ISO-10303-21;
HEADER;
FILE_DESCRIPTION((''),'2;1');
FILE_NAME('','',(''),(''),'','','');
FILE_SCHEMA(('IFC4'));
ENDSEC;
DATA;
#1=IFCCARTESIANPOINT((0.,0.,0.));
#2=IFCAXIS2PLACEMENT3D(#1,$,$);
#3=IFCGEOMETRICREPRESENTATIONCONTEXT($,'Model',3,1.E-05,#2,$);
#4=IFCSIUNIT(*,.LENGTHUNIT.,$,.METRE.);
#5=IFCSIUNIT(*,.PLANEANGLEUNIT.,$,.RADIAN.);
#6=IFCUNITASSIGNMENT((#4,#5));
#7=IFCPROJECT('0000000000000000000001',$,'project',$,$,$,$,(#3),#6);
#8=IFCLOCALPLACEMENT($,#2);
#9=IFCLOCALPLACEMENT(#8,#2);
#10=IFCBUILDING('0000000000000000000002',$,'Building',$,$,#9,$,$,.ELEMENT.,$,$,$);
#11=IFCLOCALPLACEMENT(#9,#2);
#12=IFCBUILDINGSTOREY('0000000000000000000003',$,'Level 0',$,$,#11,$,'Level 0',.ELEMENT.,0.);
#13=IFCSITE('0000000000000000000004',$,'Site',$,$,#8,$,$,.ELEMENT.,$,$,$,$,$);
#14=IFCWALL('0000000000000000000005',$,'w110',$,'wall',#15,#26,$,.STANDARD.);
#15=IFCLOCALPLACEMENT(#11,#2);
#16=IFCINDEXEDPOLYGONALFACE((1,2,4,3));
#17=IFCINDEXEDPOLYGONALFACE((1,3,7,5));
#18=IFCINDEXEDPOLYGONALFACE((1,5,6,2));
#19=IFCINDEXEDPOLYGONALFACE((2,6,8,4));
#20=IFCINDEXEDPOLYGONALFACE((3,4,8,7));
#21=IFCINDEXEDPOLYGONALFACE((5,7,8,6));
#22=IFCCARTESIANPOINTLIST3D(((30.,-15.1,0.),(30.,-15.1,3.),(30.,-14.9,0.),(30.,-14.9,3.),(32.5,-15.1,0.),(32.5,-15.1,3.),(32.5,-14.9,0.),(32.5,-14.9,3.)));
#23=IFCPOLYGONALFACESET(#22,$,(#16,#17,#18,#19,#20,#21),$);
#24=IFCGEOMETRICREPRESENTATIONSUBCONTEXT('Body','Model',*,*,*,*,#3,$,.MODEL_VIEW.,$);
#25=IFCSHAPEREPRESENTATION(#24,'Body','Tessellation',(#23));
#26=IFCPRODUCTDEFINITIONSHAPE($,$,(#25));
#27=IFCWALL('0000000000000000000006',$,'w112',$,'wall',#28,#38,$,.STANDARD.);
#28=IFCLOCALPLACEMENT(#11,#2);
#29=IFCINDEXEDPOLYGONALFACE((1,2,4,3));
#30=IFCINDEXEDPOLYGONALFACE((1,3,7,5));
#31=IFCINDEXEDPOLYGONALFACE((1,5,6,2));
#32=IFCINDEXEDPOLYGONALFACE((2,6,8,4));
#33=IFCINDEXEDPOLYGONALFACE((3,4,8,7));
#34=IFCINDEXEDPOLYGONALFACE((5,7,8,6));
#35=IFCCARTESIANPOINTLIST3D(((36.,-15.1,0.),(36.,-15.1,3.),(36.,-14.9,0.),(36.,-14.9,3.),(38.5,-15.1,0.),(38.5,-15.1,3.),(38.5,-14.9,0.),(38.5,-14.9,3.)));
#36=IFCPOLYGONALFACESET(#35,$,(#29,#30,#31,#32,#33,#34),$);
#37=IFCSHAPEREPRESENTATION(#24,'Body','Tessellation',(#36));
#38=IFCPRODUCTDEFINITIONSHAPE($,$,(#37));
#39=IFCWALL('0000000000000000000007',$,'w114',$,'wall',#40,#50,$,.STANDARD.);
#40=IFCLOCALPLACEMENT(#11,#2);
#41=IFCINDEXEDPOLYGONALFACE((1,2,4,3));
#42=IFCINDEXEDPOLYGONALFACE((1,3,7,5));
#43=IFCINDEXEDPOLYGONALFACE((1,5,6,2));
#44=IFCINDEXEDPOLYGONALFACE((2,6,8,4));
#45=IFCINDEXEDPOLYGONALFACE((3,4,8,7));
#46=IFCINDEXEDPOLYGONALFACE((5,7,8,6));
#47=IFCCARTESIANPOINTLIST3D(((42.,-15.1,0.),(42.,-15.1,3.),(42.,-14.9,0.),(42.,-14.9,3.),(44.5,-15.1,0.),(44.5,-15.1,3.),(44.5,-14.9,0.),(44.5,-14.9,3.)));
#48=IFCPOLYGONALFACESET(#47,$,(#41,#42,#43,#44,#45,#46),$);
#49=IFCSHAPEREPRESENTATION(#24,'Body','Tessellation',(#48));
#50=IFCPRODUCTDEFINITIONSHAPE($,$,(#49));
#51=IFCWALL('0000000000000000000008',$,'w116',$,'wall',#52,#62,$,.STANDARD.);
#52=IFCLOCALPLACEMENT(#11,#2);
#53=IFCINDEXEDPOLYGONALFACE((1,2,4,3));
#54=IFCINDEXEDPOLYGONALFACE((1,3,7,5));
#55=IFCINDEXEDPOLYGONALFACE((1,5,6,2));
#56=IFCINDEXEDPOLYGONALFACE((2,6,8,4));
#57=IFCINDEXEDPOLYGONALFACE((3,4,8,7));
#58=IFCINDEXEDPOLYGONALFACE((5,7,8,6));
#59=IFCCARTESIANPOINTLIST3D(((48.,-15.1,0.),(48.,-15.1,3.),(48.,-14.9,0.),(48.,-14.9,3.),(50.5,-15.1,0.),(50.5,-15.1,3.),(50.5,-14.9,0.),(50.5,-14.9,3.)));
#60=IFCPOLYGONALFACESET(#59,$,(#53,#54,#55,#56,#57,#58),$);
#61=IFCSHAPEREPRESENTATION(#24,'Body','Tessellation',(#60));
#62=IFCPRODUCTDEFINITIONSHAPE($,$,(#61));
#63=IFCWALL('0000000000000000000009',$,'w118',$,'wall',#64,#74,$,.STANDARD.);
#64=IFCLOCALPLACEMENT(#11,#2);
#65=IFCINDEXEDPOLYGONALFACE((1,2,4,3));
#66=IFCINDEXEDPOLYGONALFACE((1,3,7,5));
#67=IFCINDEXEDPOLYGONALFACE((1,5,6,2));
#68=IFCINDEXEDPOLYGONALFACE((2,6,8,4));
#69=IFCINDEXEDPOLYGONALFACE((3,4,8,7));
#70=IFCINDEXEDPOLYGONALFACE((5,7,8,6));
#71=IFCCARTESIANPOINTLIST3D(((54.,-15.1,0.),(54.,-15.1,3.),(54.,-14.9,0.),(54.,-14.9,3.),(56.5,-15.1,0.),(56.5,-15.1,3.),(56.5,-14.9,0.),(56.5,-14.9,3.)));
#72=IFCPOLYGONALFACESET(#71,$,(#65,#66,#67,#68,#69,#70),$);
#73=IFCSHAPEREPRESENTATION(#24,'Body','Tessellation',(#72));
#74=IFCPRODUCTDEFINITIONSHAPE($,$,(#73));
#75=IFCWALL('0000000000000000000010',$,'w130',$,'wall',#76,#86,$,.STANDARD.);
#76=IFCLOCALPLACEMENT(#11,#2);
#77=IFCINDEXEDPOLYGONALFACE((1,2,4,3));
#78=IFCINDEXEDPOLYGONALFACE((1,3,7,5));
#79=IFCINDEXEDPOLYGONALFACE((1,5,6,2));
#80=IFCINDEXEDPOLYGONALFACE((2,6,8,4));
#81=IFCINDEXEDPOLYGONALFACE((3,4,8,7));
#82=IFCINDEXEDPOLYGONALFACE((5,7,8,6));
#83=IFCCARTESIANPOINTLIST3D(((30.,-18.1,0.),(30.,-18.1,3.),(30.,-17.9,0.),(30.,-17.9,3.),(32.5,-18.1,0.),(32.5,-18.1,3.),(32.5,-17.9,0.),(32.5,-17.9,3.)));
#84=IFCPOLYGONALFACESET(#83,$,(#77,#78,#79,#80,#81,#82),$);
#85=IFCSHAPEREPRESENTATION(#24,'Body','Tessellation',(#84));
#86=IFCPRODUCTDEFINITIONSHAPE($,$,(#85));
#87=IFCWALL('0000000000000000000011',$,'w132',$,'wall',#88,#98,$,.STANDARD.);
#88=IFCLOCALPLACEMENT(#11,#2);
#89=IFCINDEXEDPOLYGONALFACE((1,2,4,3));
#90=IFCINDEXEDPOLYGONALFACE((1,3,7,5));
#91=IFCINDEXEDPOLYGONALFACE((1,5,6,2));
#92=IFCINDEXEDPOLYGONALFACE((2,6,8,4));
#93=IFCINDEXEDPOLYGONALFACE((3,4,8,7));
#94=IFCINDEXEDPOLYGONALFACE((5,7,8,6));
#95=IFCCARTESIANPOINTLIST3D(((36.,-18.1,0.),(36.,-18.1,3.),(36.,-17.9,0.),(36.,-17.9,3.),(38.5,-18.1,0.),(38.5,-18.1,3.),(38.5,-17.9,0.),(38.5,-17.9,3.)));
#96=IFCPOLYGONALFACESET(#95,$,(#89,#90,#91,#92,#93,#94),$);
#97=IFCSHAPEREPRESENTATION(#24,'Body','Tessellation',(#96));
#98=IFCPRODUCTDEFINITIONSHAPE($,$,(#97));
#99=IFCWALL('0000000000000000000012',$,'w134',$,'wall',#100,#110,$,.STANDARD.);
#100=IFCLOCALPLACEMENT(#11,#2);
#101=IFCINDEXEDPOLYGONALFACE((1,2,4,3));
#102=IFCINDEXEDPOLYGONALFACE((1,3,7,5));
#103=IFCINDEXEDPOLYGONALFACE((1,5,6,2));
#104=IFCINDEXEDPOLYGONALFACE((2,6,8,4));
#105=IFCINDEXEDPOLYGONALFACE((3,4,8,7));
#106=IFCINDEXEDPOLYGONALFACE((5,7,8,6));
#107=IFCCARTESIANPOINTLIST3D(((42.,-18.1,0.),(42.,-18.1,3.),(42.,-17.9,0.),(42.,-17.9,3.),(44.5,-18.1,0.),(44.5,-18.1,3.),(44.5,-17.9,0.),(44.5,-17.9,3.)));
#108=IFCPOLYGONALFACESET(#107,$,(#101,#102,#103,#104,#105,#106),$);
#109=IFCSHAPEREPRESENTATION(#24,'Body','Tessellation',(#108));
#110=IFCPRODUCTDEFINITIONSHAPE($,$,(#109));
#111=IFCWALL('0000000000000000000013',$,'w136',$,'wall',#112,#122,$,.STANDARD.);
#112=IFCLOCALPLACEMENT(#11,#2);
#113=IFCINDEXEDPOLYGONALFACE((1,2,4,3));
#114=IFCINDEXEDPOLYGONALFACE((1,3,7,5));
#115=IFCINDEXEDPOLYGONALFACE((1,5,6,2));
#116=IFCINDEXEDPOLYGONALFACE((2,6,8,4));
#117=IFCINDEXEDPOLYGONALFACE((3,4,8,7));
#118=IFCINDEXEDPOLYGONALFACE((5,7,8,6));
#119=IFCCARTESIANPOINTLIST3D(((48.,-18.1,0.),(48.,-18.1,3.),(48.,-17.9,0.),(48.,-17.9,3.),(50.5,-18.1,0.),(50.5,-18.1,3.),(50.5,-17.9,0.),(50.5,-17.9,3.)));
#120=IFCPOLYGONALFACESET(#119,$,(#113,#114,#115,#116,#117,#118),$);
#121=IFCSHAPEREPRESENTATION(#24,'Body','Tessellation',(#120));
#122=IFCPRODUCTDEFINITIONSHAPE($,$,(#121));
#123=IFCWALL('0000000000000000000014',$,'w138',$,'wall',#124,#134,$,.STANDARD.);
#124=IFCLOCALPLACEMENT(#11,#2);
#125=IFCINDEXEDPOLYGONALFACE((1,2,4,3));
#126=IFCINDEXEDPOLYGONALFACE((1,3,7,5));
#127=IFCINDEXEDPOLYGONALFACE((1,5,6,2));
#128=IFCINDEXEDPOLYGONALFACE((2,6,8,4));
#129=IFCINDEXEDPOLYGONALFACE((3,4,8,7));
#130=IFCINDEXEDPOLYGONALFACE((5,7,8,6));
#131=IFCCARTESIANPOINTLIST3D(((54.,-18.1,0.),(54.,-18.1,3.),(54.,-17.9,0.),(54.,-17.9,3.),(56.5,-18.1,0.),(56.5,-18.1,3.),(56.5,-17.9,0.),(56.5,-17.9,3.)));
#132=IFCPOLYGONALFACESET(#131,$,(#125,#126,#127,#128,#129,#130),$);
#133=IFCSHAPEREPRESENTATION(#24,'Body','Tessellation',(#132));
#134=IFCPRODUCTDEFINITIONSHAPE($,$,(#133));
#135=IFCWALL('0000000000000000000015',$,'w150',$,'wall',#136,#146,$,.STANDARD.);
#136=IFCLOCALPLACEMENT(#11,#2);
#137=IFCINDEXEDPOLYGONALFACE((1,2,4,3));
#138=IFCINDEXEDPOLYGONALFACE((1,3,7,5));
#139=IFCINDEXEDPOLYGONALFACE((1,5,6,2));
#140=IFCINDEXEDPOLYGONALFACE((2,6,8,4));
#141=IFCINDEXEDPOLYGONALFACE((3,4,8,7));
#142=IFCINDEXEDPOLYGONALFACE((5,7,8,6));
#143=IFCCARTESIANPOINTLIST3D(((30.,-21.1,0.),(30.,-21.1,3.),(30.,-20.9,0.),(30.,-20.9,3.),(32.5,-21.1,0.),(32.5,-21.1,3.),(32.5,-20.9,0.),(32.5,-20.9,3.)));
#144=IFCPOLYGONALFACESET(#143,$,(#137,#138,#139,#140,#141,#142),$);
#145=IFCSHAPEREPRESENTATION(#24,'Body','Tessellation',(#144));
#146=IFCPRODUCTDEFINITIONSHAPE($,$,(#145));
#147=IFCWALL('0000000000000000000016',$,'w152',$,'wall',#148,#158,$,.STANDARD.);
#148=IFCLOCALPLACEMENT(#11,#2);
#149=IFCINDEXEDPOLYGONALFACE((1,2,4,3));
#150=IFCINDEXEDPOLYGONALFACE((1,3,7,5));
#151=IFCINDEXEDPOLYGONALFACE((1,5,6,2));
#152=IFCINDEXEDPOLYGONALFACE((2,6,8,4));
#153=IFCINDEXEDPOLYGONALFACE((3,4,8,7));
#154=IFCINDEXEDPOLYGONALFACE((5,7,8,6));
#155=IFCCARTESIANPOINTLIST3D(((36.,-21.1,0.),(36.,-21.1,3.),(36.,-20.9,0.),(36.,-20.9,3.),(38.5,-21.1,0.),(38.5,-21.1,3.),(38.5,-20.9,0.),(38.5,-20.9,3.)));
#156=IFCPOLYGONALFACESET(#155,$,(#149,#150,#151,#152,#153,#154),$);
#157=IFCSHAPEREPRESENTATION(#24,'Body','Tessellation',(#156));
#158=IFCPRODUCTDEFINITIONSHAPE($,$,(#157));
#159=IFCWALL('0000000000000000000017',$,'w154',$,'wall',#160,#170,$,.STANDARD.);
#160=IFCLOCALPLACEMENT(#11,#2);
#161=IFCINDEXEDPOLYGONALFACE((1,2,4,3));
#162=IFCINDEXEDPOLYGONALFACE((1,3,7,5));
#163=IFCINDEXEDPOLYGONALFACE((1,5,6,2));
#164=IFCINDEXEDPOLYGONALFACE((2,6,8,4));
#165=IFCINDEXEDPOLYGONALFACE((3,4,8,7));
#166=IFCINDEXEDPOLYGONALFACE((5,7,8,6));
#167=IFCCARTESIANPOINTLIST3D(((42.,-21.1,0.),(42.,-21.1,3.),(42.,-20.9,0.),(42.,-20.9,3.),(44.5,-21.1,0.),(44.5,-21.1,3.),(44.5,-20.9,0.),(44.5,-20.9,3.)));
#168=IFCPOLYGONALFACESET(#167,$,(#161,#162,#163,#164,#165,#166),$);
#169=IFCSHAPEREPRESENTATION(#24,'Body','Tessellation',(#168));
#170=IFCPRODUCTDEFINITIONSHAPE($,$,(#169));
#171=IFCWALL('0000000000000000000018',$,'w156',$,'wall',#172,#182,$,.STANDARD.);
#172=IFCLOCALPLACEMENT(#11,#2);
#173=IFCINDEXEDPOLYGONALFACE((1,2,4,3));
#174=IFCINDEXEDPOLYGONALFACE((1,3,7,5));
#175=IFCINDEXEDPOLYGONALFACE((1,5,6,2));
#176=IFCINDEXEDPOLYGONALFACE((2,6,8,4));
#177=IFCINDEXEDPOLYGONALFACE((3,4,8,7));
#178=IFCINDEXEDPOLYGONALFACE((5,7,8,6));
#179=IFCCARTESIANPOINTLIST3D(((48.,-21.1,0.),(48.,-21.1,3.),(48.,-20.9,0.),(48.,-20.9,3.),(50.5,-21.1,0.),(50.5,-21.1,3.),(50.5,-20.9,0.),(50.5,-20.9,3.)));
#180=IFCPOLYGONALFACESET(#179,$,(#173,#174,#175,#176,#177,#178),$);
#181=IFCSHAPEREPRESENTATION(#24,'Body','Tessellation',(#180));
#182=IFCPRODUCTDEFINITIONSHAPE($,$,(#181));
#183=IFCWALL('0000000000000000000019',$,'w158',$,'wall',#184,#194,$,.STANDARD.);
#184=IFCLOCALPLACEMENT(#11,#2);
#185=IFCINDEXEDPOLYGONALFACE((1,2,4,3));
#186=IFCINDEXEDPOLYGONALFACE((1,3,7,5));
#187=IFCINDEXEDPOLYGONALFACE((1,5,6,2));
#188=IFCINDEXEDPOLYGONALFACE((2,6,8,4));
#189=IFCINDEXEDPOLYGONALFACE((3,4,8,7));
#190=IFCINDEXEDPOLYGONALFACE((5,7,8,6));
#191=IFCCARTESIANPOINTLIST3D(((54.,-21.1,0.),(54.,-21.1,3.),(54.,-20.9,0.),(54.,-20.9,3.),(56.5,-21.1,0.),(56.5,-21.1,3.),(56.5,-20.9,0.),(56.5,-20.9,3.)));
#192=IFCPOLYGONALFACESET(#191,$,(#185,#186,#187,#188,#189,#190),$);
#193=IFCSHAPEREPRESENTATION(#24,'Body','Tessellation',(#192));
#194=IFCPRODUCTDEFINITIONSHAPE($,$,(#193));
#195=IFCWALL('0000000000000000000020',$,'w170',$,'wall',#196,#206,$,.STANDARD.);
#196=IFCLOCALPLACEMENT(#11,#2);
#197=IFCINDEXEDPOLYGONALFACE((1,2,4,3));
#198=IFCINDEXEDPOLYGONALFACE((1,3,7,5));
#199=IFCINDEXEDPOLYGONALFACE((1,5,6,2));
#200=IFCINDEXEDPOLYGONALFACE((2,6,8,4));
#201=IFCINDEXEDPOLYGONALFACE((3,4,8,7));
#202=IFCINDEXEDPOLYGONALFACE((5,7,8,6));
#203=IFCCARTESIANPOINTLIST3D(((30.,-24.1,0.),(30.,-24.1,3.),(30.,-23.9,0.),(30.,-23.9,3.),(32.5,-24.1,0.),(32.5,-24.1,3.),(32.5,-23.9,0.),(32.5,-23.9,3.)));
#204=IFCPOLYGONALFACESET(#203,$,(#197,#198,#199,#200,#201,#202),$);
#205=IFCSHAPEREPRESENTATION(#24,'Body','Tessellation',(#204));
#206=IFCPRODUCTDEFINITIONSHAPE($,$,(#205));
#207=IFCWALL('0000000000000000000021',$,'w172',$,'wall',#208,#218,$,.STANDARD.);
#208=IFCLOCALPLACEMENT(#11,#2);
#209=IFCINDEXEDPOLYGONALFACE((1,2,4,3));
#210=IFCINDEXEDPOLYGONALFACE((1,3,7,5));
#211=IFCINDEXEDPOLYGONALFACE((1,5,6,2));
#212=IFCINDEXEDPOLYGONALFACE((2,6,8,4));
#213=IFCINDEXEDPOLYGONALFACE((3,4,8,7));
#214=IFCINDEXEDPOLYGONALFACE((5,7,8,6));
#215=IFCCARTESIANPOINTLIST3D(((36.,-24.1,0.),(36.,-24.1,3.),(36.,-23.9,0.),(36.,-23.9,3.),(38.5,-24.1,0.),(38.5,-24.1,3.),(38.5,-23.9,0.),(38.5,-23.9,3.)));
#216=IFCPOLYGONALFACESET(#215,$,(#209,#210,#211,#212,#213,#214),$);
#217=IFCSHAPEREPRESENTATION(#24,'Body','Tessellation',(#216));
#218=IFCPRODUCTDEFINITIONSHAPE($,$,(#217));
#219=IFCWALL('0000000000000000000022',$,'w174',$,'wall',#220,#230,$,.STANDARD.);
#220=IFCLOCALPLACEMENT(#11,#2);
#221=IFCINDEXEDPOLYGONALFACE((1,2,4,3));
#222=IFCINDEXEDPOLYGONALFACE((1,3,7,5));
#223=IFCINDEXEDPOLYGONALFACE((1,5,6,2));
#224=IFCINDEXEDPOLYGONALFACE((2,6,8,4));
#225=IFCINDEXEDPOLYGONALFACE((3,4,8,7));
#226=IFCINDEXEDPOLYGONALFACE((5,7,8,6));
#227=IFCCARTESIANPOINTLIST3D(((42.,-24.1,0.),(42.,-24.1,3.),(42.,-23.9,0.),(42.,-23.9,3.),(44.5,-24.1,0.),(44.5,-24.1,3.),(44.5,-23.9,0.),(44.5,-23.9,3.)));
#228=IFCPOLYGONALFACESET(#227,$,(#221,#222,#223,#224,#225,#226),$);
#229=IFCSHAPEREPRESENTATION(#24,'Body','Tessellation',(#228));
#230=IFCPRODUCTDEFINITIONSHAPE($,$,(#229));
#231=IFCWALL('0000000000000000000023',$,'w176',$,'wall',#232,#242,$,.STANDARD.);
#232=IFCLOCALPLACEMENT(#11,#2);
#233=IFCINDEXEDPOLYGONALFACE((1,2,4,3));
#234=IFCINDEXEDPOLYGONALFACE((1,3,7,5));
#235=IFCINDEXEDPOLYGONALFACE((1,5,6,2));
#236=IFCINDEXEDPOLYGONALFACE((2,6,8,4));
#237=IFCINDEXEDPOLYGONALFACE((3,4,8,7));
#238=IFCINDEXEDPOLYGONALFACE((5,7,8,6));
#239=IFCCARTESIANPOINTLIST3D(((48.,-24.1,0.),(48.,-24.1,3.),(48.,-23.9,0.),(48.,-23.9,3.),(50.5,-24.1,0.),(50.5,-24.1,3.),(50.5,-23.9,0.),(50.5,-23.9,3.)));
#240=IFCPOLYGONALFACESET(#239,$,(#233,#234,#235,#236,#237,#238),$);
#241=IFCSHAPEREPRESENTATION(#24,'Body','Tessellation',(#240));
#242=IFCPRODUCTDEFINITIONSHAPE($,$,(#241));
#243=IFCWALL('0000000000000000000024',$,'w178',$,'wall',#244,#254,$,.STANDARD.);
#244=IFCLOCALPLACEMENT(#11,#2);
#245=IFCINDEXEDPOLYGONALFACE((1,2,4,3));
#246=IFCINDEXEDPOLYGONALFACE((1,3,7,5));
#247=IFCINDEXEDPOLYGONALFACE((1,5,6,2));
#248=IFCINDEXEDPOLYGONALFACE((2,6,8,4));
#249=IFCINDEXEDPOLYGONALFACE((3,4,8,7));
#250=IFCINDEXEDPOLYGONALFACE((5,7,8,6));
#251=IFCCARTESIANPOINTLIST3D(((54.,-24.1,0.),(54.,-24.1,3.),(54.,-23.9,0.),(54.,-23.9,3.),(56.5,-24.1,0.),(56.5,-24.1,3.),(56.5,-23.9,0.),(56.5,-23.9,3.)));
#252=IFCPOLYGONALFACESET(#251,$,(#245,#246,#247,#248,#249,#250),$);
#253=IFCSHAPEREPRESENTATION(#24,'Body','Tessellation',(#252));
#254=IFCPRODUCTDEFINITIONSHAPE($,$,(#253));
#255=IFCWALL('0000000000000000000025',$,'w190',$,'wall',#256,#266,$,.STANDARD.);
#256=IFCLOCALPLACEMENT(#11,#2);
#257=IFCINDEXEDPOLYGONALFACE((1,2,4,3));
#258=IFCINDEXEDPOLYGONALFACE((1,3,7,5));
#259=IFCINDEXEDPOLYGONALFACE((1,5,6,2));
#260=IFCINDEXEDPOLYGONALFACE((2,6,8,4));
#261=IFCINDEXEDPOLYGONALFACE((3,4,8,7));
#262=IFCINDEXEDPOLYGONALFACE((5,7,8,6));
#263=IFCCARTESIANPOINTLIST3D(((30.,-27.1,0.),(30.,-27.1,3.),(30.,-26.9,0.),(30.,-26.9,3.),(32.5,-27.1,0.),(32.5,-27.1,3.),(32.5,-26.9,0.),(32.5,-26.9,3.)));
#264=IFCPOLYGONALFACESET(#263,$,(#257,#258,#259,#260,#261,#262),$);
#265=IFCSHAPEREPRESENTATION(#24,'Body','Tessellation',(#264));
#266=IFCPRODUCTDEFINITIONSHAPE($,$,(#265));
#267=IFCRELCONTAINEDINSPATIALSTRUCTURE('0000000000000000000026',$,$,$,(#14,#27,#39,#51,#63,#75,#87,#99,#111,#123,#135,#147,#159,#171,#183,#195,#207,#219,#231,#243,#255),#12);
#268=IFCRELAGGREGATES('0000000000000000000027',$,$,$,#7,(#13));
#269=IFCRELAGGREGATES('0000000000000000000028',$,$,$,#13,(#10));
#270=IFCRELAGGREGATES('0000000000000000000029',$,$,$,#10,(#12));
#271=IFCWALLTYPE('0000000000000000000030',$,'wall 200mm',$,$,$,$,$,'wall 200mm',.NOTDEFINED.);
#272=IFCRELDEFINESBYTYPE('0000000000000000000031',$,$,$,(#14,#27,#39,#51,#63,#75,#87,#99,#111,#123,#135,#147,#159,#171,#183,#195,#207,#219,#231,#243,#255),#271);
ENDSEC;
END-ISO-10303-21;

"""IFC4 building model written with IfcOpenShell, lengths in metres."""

from ifc_helpers import new_model, si_unit, frame, frame_2d, origin, place, context, subcontext, project, spatial, rectangle, extrude, type_object, element, save


model = new_model("IFC4")

# Units and contexts
model_context = context("Model", 3, precision=1e-05, world=origin())
body_context = subcontext(model_context, "Body", "Model", "MODEL_VIEW")
ifc_project = project(units=[si_unit("LENGTHUNIT", "METRE"), si_unit("PLANEANGLEUNIT", "RADIAN")], contexts=[model_context])

# Site, building, storey
site_placement = place(None, origin())
site = spatial("IfcSite", under=ifc_project, at=site_placement, Name="Site", CompositionType="ELEMENT")
building_placement = place(site_placement, origin())
building = spatial("IfcBuilding", under=site, at=building_placement, Name="Building", CompositionType="ELEMENT")
storey_placement = place(building_placement, origin())
storey = spatial("IfcBuildingStorey", under=building, at=storey_placement, Name="Level 0", LongName="Level 0", CompositionType="ELEMENT", Elevation=0.0)

# Walls
wall_type = type_object("IfcWallType", Name="wall 200mm", ElementType="wall 200mm", PredefinedType="NOTDEFINED")
for number, where, z_axis, x_axis, name in (
    (1, (30.0, -15.0, 0.0), (0.0, 0.0, 1.0), (1.0, 0.0, 0.0), "w110"),
    (2, (36.0, -15.0, 0.0), (0.0, 0.0, 1.0), (1.0, 0.0, 0.0), "w112"),
    (3, (42.0, -15.0, 0.0), (0.0, 0.0, 1.0), (1.0, 0.0, 0.0), "w114"),
    (4, (48.0, -15.0, 0.0), (0.0, 0.0, 1.0), (1.0, 0.0, 0.0), "w116"),
    (5, (54.0, -15.0, 0.0), (0.0, 0.0, 1.0), (1.0, 0.0, 0.0), "w118"),
    (6, (30.0, -18.0, 0.0), (0.0, 0.0, 1.0), (1.0, 0.0, 0.0), "w130"),
    (7, (36.0, -18.0, 0.0), (0.0, 0.0, 1.0), (1.0, 0.0, 0.0), "w132"),
    (8, (42.0, -18.0, 0.0), (0.0, 0.0, 1.0), (1.0, 0.0, 0.0), "w134"),
    (9, (48.0, -18.0, 0.0), (0.0, 0.0, 1.0), (1.0, 0.0, 0.0), "w136"),
    (10, (54.0, -18.0, 0.0), (0.0, 0.0, 1.0), (1.0, 0.0, 0.0), "w138"),
    (11, (30.0, -21.0, 0.0), (0.0, 0.0, 1.0), (1.0, 0.0, 0.0), "w150"),
    (12, (36.0, -21.0, 0.0), (0.0, 0.0, 1.0), (1.0, 0.0, 0.0), "w152"),
    (13, (42.0, -21.0, 0.0), (0.0, 0.0, 1.0), (1.0, 0.0, 0.0), "w154"),
    (14, (48.0, -21.0, 0.0), (0.0, 0.0, 1.0), (1.0, 0.0, 0.0), "w156"),
    (15, (54.0, -21.0, 0.0), (0.0, 0.0, 1.0), (1.0, 0.0, 0.0), "w158"),
    (16, (30.0, -24.0, 0.0), (0.0, 0.0, 1.0), (1.0, 0.0, 0.0), "w170"),
    (17, (36.0, -24.0, 0.0), (0.0, 0.0, 1.0), (1.0, 0.0, 0.0), "w172"),
    (18, (42.0, -24.0, 0.0), (0.0, 0.0, 1.0), (1.0, 0.0, 0.0), "w174"),
    (19, (48.0, -24.0, 0.0), (0.0, 0.0, 1.0), (1.0, 0.0, 0.0), "w176"),
    (20, (54.0, -24.0, 0.0), (0.0, 0.0, 1.0), (1.0, 0.0, 0.0), "w178"),
    (21, (30.0, -27.0, 0.0), (0.0, 0.0, 1.0), (1.0, 0.0, 0.0), "w190"),
):
    element("IfcWall", number, at=place(storey_placement, frame(where, z_axis=z_axis, x_axis=x_axis)), inside=storey, type_object=wall_type, Name=name, ObjectType="wall", PredefinedType="STANDARD", context=body_context, shape_type="SweptSolid", body=[
        extrude(rectangle(XDim=2.5, YDim=0.2, at=frame_2d((1.25, 0.0))), origin(), (0.0, 0.0, 1.0), 3.0),
    ])

save(model, "model.ifc")
